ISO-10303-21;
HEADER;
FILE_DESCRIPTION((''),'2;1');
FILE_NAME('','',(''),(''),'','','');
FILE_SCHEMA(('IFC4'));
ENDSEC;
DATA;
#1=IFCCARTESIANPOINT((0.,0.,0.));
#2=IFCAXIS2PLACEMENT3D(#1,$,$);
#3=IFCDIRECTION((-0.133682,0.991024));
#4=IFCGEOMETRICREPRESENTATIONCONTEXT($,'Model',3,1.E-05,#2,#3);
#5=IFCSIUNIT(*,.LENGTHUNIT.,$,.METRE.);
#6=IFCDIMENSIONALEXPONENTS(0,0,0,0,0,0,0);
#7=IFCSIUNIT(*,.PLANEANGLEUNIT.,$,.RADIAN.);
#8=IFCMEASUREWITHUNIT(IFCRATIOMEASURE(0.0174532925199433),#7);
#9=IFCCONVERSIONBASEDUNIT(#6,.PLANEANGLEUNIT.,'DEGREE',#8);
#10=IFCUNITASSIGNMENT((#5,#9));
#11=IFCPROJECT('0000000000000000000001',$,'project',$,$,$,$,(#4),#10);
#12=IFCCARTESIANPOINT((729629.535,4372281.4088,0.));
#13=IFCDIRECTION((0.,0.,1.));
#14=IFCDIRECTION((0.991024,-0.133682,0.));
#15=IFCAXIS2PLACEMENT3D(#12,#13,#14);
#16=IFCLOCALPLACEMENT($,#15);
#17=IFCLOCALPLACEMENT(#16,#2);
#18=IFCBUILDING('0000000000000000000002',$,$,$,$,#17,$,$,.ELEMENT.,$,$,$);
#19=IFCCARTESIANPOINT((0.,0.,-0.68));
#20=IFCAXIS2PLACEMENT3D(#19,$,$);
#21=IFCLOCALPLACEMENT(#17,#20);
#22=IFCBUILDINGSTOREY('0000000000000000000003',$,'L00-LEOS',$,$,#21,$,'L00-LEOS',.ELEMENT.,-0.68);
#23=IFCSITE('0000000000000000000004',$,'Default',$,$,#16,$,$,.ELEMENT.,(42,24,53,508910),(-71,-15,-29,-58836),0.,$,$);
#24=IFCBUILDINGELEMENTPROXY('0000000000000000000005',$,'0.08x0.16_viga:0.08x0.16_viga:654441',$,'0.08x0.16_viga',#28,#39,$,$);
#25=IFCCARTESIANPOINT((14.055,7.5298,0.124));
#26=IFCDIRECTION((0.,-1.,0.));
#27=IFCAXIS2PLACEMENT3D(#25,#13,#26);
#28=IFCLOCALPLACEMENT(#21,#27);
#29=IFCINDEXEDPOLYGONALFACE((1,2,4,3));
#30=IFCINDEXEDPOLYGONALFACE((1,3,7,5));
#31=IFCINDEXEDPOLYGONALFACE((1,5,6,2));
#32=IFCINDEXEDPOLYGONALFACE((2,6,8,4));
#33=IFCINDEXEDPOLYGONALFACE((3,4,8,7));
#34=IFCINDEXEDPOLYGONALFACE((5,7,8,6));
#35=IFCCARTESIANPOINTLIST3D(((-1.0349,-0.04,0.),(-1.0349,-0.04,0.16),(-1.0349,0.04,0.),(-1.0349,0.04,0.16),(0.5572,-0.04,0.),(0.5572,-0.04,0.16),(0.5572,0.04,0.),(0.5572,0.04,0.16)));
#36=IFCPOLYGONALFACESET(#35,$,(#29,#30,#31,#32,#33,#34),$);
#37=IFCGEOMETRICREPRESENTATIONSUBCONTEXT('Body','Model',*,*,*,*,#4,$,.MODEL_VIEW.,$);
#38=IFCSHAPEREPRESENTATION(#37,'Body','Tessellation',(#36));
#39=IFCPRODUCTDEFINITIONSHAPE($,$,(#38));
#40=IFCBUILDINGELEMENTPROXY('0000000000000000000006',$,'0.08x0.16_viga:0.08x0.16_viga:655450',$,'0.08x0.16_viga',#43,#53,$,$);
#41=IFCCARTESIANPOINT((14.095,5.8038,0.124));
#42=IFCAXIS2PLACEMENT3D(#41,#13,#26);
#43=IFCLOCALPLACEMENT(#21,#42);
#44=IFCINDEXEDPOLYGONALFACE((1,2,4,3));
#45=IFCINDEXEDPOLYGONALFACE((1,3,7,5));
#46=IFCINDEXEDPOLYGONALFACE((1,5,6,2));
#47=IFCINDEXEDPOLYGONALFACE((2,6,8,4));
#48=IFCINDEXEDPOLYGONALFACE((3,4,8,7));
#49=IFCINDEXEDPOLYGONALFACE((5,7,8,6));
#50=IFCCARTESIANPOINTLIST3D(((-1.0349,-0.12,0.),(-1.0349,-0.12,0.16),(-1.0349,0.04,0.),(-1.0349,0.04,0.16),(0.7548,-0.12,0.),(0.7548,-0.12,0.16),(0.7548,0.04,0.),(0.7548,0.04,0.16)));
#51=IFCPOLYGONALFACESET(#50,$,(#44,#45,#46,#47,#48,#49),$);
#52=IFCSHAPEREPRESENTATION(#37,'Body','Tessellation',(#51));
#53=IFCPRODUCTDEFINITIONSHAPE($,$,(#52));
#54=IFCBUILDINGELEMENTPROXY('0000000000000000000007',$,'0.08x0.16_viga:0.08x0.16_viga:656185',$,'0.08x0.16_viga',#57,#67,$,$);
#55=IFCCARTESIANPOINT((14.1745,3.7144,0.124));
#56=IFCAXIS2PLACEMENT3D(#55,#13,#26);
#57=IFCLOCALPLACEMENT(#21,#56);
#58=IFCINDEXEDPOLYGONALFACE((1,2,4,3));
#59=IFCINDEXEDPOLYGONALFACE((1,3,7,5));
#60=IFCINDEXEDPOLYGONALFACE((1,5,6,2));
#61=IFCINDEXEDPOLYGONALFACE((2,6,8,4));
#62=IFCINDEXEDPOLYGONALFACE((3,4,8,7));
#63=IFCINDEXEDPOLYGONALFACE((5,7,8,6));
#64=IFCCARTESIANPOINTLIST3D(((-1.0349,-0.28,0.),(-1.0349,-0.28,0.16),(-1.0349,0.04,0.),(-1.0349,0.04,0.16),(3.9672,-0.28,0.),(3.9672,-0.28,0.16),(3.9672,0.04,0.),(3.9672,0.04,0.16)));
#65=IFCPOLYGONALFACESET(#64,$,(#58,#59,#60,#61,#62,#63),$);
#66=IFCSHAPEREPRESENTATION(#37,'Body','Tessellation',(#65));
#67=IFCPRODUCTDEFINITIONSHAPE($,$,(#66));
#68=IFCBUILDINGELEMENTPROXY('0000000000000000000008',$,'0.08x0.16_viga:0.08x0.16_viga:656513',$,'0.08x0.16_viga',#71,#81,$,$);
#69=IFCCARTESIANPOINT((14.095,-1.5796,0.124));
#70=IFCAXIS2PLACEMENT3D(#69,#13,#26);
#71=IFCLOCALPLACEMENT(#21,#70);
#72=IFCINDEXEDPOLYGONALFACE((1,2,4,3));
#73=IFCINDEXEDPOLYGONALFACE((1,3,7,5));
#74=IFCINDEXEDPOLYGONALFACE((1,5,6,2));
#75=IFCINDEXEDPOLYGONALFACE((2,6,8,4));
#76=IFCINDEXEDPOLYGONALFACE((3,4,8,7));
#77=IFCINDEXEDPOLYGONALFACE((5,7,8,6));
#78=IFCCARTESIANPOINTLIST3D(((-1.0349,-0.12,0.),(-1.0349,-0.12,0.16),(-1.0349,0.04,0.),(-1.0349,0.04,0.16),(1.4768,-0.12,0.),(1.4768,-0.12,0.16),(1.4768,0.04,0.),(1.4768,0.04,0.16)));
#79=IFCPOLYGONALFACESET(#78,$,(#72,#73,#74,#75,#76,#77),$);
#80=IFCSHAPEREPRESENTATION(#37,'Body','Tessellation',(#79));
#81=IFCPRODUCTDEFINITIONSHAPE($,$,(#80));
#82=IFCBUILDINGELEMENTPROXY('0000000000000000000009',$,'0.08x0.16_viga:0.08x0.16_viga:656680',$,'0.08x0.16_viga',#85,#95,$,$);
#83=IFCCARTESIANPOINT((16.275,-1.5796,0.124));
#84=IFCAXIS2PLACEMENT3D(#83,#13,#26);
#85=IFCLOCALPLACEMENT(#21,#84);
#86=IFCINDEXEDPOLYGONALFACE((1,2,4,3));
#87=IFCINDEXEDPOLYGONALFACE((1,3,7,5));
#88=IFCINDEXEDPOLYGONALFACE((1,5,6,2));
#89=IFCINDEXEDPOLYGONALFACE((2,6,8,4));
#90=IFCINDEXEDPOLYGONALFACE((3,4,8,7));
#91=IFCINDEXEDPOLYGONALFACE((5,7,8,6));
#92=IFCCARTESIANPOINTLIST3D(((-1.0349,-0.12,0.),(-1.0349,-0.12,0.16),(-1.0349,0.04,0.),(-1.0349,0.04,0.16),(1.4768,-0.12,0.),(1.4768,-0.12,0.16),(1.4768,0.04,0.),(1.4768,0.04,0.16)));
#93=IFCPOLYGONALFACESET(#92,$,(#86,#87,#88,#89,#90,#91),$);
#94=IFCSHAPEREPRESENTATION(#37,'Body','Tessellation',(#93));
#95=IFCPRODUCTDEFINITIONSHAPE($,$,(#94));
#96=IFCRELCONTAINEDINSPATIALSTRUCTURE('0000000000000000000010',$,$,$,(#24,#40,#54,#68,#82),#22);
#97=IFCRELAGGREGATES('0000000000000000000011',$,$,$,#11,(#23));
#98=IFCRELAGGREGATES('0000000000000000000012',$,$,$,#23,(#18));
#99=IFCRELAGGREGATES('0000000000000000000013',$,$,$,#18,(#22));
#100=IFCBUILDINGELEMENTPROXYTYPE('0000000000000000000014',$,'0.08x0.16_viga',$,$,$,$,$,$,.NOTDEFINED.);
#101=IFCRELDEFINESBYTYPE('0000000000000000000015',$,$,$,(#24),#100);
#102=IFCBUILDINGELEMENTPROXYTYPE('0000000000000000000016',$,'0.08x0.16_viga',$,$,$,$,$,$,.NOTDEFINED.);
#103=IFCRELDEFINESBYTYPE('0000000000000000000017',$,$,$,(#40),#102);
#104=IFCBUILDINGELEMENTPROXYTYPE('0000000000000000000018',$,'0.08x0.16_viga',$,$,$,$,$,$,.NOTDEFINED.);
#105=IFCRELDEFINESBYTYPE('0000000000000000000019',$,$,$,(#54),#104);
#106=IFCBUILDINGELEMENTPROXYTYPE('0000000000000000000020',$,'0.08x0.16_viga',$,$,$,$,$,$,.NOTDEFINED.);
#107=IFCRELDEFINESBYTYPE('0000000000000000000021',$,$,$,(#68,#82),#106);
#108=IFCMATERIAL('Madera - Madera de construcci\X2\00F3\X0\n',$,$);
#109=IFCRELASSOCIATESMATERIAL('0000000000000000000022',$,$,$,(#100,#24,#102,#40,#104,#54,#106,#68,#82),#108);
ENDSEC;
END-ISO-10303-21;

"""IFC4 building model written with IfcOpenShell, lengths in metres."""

from ifc_helpers import new_model, entity, si_unit, converted_unit, direction, frame, origin, origin_2d_with_axis, place, context, subcontext, project, spatial, rectangle, extrude, source, transform, mapped, material, type_object, type_shapes, element, save


model = new_model("IFC4")

# Units and contexts
model_context = context("Model", 3, precision=1e-05, world=origin(), true_north=direction((-0.133682, 0.991024)))
body_context = subcontext(model_context, "Body", "Model", "MODEL_VIEW")
ifc_project = project(units=[si_unit("LENGTHUNIT", "METRE"), converted_unit("PLANEANGLEUNIT", "DEGREE", entity("IfcRatioMeasure", 0.0174532925199433), si_unit("PLANEANGLEUNIT", "RADIAN"), dimensions=[0, 0, 0, 0, 0, 0, 0])], contexts=[model_context])

# Site, building, storey
site_placement = place(None, frame((729629.535, 4372281.4088, 0.0), z_axis=(0.0, 0.0, 1.0), x_axis=(0.991024, -0.133682, 0.0)))
site = spatial("IfcSite", under=ifc_project, at=site_placement, Name="Default", CompositionType="ELEMENT", RefLatitude=(42, 24, 53, 508910), RefLongitude=(-71, -15, -29, -58836), RefElevation=0.0)
building_placement = place(site_placement, origin())
building = spatial("IfcBuilding", under=site, at=building_placement, CompositionType="ELEMENT")
storey_placement = place(building_placement, frame((0.0, 0.0, -0.68)))
storey = spatial("IfcBuildingStorey", under=building, at=storey_placement, Name="L00-LEOS", LongName="L00-LEOS", CompositionType="ELEMENT", Elevation=-0.68)

# Building element proxies
ifc_material_1 = material(Name="Madera - Madera de construcción")
building_element_proxy_type_1 = type_object("IfcBuildingElementProxyType", Name="0.08x0.16_viga", material=ifc_material_1)
shared_shape_1 = source(origin(), body_context, "Body", "SweptSolid", [
    extrude(rectangle(XDim=0.08, YDim=1.5922, at=origin_2d_with_axis()), frame((-0.2389, 0.0, 0.0), z_axis=(0.0, 0.0, 1.0), x_axis=(0.0, -1.0, 0.0)), (0.0, 0.0, 1.0), 0.16),
])
type_shapes(building_element_proxy_type_1, [shared_shape_1])
proxy_1_placement = place(storey_placement, frame((14.055, 7.5298, 0.124), z_axis=(0.0, 0.0, 1.0), x_axis=(0.0, -1.0, 0.0)))
element("IfcBuildingElementProxy", 1, at=proxy_1_placement, inside=storey, type_object=building_element_proxy_type_1, material=ifc_material_1, Name="0.08x0.16_viga:0.08x0.16_viga:654441", ObjectType="0.08x0.16_viga", context=body_context, shape_type="MappedRepresentation", body=[
    mapped(shared_shape_1, transform((0.0, 0.0, 0.0), scale=1.0)),
])
building_element_proxy_type_2 = type_object("IfcBuildingElementProxyType", Name="0.08x0.16_viga", material=ifc_material_1)
shared_shape_2 = source(origin(), body_context, "Body", "SweptSolid", [
    extrude(rectangle(XDim=0.16, YDim=1.7897, at=origin_2d_with_axis()), frame((-0.1401, -0.04, 0.0), z_axis=(0.0, 0.0, 1.0), x_axis=(0.0, -1.0, 0.0)), (0.0, 0.0, 1.0), 0.16),
])
type_shapes(building_element_proxy_type_2, [shared_shape_2])
proxy_2_placement = place(storey_placement, frame((14.095, 5.8038, 0.124), z_axis=(0.0, 0.0, 1.0), x_axis=(0.0, -1.0, 0.0)))
element("IfcBuildingElementProxy", 2, at=proxy_2_placement, inside=storey, type_object=building_element_proxy_type_2, material=ifc_material_1, Name="0.08x0.16_viga:0.08x0.16_viga:655450", ObjectType="0.08x0.16_viga", context=body_context, shape_type="MappedRepresentation", body=[
    mapped(shared_shape_2, transform((0.0, 0.0, 0.0), scale=1.0)),
])
building_element_proxy_type_3 = type_object("IfcBuildingElementProxyType", Name="0.08x0.16_viga", material=ifc_material_1)
shared_shape_3 = source(origin(), body_context, "Body", "SweptSolid", [
    extrude(rectangle(XDim=0.32, YDim=5.0021, at=origin_2d_with_axis()), frame((1.4661, -0.12, 0.0), z_axis=(0.0, 0.0, 1.0), x_axis=(0.0, -1.0, 0.0)), (0.0, 0.0, 1.0), 0.16),
])
type_shapes(building_element_proxy_type_3, [shared_shape_3])
proxy_3_placement = place(storey_placement, frame((14.1745, 3.7144, 0.124), z_axis=(0.0, 0.0, 1.0), x_axis=(0.0, -1.0, 0.0)))
element("IfcBuildingElementProxy", 3, at=proxy_3_placement, inside=storey, type_object=building_element_proxy_type_3, material=ifc_material_1, Name="0.08x0.16_viga:0.08x0.16_viga:656185", ObjectType="0.08x0.16_viga", context=body_context, shape_type="MappedRepresentation", body=[
    mapped(shared_shape_3, transform((0.0, 0.0, 0.0), scale=1.0)),
])
building_element_proxy_type_4 = type_object("IfcBuildingElementProxyType", Name="0.08x0.16_viga", material=ifc_material_1)
shared_shape_4 = source(origin(), body_context, "Body", "SweptSolid", [
    extrude(rectangle(XDim=0.16, YDim=2.5117, at=origin_2d_with_axis()), frame((0.2209, -0.04, 0.0), z_axis=(0.0, 0.0, 1.0), x_axis=(0.0, -1.0, 0.0)), (0.0, 0.0, 1.0), 0.16),
])
type_shapes(building_element_proxy_type_4, [shared_shape_4])
for number, where, z_axis, x_axis, name in (
    (4, (14.095, -1.5796, 0.124), (0.0, 0.0, 1.0), (0.0, -1.0, 0.0), "0.08x0.16_viga:0.08x0.16_viga:656513"),
    (5, (16.275, -1.5796, 0.124), (0.0, 0.0, 1.0), (0.0, -1.0, 0.0), "0.08x0.16_viga:0.08x0.16_viga:656680"),
):
    element("IfcBuildingElementProxy", number, at=place(storey_placement, frame(where, z_axis=z_axis, x_axis=x_axis)), inside=storey, type_object=building_element_proxy_type_4, material=ifc_material_1, Name=name, ObjectType="0.08x0.16_viga", context=body_context, shape_type="MappedRepresentation", body=[
        mapped(shared_shape_4, transform((0.0, 0.0, 0.0), scale=1.0)),
    ])

save(model, "model.ifc")
